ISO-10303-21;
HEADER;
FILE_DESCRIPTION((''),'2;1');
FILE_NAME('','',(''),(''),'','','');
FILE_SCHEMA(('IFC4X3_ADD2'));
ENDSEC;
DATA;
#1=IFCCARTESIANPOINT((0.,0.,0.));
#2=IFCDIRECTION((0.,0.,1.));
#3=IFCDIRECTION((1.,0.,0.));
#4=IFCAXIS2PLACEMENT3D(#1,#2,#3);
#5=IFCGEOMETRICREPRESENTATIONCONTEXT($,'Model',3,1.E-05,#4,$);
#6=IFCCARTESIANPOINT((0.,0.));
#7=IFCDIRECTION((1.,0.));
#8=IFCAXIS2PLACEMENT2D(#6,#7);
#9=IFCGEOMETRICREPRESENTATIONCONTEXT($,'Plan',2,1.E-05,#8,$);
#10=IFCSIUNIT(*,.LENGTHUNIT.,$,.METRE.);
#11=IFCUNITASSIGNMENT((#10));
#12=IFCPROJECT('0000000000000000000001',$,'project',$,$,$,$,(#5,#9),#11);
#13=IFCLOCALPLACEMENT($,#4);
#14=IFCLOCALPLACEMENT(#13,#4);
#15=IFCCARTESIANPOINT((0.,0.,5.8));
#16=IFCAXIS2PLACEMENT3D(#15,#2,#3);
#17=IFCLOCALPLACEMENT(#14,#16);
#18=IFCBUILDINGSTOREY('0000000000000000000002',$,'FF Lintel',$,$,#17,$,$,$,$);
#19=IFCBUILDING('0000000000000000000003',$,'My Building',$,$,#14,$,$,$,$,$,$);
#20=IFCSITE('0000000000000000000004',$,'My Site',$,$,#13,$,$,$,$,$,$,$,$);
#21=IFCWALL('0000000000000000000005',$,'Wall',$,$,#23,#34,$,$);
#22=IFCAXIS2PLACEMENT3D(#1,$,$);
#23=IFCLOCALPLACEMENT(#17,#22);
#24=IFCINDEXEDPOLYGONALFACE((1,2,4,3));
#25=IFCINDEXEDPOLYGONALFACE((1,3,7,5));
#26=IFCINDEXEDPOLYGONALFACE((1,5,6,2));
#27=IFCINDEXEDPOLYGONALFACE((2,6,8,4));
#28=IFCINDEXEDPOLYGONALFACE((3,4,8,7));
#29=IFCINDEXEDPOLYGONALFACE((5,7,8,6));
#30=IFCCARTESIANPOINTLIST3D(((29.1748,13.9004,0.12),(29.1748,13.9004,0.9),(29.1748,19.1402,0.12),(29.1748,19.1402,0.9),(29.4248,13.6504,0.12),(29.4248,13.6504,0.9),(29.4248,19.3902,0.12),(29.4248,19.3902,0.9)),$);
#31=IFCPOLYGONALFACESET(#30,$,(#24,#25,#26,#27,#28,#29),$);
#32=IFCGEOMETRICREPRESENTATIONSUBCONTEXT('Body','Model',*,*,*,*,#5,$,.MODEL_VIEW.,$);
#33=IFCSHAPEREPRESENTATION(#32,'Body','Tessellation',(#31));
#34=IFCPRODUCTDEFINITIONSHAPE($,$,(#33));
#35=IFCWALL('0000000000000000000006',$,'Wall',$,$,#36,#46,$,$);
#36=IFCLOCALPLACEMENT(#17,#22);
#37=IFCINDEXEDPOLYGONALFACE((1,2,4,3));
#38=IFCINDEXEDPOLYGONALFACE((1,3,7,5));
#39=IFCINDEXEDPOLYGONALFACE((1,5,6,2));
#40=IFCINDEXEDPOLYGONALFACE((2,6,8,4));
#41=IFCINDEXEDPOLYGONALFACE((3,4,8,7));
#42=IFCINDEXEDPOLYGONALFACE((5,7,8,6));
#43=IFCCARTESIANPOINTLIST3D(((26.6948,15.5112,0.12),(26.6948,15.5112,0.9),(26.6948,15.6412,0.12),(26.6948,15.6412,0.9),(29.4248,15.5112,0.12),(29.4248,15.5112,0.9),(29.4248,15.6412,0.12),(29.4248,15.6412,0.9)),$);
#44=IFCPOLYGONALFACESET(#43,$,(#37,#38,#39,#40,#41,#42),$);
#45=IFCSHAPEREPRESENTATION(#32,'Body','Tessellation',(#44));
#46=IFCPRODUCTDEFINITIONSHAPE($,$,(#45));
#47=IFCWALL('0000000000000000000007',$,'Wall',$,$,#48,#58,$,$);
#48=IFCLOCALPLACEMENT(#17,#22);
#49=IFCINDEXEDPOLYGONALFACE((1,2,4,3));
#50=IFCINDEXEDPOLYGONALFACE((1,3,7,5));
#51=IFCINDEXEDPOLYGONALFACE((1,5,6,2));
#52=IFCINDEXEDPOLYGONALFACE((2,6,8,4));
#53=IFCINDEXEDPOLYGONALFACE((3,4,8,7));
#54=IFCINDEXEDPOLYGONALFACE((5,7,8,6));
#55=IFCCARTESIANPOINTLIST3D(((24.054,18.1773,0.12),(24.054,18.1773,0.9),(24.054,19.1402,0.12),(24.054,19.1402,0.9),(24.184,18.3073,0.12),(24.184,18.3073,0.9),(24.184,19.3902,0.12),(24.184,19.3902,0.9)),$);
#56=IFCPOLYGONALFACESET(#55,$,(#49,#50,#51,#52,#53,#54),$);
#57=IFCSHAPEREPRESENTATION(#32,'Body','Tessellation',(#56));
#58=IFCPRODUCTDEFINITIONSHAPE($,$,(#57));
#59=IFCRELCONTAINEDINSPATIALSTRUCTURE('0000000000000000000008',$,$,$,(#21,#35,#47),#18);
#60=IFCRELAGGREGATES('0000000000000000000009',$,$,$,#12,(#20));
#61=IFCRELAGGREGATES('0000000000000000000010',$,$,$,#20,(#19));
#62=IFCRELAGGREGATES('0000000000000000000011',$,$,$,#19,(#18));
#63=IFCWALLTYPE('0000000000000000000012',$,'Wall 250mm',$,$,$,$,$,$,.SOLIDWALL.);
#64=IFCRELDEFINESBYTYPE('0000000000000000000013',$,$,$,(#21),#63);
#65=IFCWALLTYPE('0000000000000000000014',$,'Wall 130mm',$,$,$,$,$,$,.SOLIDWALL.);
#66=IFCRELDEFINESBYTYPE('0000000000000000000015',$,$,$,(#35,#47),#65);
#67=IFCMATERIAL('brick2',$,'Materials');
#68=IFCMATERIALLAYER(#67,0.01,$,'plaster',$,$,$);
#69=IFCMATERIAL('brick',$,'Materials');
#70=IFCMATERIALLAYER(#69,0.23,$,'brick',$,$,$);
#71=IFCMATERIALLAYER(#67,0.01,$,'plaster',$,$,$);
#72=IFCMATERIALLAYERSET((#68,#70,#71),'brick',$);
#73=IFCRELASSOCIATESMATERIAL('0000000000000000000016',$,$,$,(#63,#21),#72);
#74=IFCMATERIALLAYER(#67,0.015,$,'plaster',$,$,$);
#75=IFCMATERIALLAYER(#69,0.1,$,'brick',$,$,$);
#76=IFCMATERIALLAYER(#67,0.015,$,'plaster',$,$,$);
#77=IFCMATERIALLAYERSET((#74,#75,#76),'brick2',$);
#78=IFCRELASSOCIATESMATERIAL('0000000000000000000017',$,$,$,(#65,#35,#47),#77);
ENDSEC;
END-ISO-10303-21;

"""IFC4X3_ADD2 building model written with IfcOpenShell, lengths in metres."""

from ifc_helpers import new_model, si_unit, frame, origin_with_axes, origin_2d_with_axis, place, context, subcontext, project, spatial, line, indexed_curve, outline, extrude, material, layer, layer_set, layer_usage, type_object, element, save


model = new_model("IFC4X3_ADD2")

# Units and contexts
model_context = context("Model", 3, precision=1e-05, world=origin_with_axes())
plan_context = context("Plan", 2, precision=1e-05, world=origin_2d_with_axis())
body_context = subcontext(model_context, "Body", "Model", "MODEL_VIEW")
ifc_project = project(units=[si_unit("LENGTHUNIT", "METRE")], contexts=[model_context, plan_context])

# Site, building, storey
site_placement = place(None, origin_with_axes())
site = spatial("IfcSite", under=ifc_project, at=site_placement, Name="My Site")
building_placement = place(site_placement, origin_with_axes())
building = spatial("IfcBuilding", under=site, at=building_placement, Name="My Building")
storey_placement = place(building_placement, frame((0.0, 0.0, 5.8), z_axis=(0.0, 0.0, 1.0), x_axis=(1.0, 0.0, 0.0)))
storey = spatial("IfcBuildingStorey", under=building, at=storey_placement, Name="FF Lintel")

# Walls
ifc_material_1 = material(Name="brick2", Category="Materials")
ifc_layer_1 = layer(ifc_material_1, 0.01, Name="plaster")
ifc_material_2 = material(Name="brick", Category="Materials")
ifc_layer_2 = layer(ifc_material_2, 0.23, Name="brick")
ifc_layer_3 = layer(ifc_material_1, 0.01, Name="plaster")
ifc_layer_set_1 = layer_set([ifc_layer_1, ifc_layer_2, ifc_layer_3], Name="brick")
wall_type_1 = type_object("IfcWallType", Name="Wall 250mm", PredefinedType="SOLIDWALL", material=ifc_layer_set_1)
ifc_layer_usage_1 = layer_usage(ifc_layer_set_1, "AXIS2", "POSITIVE", 0.0)
wall_1_placement = place(storey_placement, frame((29.4248, 13.6504, 0.12), z_axis=(0.0, 0.0, 1.0), x_axis=(0.000001, 1.0, 0.0)))
element("IfcWall", 1, at=wall_1_placement, inside=storey, type_object=wall_type_1, material=ifc_layer_usage_1, Name="Wall", context=body_context, shape_type="SweptSolid", body=[
    extrude(outline(indexed_curve([(0.0, 0.0), (0.25, 0.25), (5.4898, 0.25), (5.7398, 0.0)], segments=[line(1, 2, 3, 4, 1)])), origin_with_axes(), (0.0, 0.0, 1.0), 0.78),
])
ifc_layer_4 = layer(ifc_material_1, 0.015, Name="plaster")
ifc_layer_5 = layer(ifc_material_2, 0.1, Name="brick")
ifc_layer_6 = layer(ifc_material_1, 0.015, Name="plaster")
ifc_layer_set_2 = layer_set([ifc_layer_4, ifc_layer_5, ifc_layer_6], Name="brick2")
wall_type_2 = type_object("IfcWallType", Name="Wall 130mm", PredefinedType="SOLIDWALL", material=ifc_layer_set_2)
ifc_layer_usage_2 = layer_usage(ifc_layer_set_2, "AXIS2", "POSITIVE", 0.0)
wall_2_placement = place(storey_placement, frame((29.4248, 15.6412, 0.12), z_axis=(0.0, 0.0, 1.0), x_axis=(-1.0, 0.0, 0.0)))
element("IfcWall", 2, at=wall_2_placement, inside=storey, type_object=wall_type_2, material=ifc_layer_usage_2, Name="Wall", context=body_context, shape_type="SweptSolid", body=[
    extrude(outline(indexed_curve([(0.0, 0.0), (0.0, 0.13), (2.73, 0.13), (2.73, 0.0)], segments=[line(1, 2, 3, 4, 1)])), origin_with_axes(), (0.0, 0.0, 1.0), 0.78),
])
ifc_layer_usage_3 = layer_usage(ifc_layer_set_2, "AXIS2", "POSITIVE", 0.0)
wall_3_placement = place(storey_placement, frame((24.184, 18.3073, 0.12), z_axis=(0.0, 0.0, 1.0), x_axis=(0.000001, 1.0, 0.0)))
element("IfcWall", 3, at=wall_3_placement, inside=storey, type_object=wall_type_2, material=ifc_layer_usage_3, Name="Wall", context=body_context, shape_type="SweptSolid", body=[
    extrude(outline(indexed_curve([(0.0, 0.0), (-0.13, 0.13), (0.8329, 0.13), (1.0829, 0.0)], segments=[line(1, 2, 3, 4, 1)])), origin_with_axes(), (0.0, 0.0, 1.0), 0.78),
])

save(model, "model.ifc")
